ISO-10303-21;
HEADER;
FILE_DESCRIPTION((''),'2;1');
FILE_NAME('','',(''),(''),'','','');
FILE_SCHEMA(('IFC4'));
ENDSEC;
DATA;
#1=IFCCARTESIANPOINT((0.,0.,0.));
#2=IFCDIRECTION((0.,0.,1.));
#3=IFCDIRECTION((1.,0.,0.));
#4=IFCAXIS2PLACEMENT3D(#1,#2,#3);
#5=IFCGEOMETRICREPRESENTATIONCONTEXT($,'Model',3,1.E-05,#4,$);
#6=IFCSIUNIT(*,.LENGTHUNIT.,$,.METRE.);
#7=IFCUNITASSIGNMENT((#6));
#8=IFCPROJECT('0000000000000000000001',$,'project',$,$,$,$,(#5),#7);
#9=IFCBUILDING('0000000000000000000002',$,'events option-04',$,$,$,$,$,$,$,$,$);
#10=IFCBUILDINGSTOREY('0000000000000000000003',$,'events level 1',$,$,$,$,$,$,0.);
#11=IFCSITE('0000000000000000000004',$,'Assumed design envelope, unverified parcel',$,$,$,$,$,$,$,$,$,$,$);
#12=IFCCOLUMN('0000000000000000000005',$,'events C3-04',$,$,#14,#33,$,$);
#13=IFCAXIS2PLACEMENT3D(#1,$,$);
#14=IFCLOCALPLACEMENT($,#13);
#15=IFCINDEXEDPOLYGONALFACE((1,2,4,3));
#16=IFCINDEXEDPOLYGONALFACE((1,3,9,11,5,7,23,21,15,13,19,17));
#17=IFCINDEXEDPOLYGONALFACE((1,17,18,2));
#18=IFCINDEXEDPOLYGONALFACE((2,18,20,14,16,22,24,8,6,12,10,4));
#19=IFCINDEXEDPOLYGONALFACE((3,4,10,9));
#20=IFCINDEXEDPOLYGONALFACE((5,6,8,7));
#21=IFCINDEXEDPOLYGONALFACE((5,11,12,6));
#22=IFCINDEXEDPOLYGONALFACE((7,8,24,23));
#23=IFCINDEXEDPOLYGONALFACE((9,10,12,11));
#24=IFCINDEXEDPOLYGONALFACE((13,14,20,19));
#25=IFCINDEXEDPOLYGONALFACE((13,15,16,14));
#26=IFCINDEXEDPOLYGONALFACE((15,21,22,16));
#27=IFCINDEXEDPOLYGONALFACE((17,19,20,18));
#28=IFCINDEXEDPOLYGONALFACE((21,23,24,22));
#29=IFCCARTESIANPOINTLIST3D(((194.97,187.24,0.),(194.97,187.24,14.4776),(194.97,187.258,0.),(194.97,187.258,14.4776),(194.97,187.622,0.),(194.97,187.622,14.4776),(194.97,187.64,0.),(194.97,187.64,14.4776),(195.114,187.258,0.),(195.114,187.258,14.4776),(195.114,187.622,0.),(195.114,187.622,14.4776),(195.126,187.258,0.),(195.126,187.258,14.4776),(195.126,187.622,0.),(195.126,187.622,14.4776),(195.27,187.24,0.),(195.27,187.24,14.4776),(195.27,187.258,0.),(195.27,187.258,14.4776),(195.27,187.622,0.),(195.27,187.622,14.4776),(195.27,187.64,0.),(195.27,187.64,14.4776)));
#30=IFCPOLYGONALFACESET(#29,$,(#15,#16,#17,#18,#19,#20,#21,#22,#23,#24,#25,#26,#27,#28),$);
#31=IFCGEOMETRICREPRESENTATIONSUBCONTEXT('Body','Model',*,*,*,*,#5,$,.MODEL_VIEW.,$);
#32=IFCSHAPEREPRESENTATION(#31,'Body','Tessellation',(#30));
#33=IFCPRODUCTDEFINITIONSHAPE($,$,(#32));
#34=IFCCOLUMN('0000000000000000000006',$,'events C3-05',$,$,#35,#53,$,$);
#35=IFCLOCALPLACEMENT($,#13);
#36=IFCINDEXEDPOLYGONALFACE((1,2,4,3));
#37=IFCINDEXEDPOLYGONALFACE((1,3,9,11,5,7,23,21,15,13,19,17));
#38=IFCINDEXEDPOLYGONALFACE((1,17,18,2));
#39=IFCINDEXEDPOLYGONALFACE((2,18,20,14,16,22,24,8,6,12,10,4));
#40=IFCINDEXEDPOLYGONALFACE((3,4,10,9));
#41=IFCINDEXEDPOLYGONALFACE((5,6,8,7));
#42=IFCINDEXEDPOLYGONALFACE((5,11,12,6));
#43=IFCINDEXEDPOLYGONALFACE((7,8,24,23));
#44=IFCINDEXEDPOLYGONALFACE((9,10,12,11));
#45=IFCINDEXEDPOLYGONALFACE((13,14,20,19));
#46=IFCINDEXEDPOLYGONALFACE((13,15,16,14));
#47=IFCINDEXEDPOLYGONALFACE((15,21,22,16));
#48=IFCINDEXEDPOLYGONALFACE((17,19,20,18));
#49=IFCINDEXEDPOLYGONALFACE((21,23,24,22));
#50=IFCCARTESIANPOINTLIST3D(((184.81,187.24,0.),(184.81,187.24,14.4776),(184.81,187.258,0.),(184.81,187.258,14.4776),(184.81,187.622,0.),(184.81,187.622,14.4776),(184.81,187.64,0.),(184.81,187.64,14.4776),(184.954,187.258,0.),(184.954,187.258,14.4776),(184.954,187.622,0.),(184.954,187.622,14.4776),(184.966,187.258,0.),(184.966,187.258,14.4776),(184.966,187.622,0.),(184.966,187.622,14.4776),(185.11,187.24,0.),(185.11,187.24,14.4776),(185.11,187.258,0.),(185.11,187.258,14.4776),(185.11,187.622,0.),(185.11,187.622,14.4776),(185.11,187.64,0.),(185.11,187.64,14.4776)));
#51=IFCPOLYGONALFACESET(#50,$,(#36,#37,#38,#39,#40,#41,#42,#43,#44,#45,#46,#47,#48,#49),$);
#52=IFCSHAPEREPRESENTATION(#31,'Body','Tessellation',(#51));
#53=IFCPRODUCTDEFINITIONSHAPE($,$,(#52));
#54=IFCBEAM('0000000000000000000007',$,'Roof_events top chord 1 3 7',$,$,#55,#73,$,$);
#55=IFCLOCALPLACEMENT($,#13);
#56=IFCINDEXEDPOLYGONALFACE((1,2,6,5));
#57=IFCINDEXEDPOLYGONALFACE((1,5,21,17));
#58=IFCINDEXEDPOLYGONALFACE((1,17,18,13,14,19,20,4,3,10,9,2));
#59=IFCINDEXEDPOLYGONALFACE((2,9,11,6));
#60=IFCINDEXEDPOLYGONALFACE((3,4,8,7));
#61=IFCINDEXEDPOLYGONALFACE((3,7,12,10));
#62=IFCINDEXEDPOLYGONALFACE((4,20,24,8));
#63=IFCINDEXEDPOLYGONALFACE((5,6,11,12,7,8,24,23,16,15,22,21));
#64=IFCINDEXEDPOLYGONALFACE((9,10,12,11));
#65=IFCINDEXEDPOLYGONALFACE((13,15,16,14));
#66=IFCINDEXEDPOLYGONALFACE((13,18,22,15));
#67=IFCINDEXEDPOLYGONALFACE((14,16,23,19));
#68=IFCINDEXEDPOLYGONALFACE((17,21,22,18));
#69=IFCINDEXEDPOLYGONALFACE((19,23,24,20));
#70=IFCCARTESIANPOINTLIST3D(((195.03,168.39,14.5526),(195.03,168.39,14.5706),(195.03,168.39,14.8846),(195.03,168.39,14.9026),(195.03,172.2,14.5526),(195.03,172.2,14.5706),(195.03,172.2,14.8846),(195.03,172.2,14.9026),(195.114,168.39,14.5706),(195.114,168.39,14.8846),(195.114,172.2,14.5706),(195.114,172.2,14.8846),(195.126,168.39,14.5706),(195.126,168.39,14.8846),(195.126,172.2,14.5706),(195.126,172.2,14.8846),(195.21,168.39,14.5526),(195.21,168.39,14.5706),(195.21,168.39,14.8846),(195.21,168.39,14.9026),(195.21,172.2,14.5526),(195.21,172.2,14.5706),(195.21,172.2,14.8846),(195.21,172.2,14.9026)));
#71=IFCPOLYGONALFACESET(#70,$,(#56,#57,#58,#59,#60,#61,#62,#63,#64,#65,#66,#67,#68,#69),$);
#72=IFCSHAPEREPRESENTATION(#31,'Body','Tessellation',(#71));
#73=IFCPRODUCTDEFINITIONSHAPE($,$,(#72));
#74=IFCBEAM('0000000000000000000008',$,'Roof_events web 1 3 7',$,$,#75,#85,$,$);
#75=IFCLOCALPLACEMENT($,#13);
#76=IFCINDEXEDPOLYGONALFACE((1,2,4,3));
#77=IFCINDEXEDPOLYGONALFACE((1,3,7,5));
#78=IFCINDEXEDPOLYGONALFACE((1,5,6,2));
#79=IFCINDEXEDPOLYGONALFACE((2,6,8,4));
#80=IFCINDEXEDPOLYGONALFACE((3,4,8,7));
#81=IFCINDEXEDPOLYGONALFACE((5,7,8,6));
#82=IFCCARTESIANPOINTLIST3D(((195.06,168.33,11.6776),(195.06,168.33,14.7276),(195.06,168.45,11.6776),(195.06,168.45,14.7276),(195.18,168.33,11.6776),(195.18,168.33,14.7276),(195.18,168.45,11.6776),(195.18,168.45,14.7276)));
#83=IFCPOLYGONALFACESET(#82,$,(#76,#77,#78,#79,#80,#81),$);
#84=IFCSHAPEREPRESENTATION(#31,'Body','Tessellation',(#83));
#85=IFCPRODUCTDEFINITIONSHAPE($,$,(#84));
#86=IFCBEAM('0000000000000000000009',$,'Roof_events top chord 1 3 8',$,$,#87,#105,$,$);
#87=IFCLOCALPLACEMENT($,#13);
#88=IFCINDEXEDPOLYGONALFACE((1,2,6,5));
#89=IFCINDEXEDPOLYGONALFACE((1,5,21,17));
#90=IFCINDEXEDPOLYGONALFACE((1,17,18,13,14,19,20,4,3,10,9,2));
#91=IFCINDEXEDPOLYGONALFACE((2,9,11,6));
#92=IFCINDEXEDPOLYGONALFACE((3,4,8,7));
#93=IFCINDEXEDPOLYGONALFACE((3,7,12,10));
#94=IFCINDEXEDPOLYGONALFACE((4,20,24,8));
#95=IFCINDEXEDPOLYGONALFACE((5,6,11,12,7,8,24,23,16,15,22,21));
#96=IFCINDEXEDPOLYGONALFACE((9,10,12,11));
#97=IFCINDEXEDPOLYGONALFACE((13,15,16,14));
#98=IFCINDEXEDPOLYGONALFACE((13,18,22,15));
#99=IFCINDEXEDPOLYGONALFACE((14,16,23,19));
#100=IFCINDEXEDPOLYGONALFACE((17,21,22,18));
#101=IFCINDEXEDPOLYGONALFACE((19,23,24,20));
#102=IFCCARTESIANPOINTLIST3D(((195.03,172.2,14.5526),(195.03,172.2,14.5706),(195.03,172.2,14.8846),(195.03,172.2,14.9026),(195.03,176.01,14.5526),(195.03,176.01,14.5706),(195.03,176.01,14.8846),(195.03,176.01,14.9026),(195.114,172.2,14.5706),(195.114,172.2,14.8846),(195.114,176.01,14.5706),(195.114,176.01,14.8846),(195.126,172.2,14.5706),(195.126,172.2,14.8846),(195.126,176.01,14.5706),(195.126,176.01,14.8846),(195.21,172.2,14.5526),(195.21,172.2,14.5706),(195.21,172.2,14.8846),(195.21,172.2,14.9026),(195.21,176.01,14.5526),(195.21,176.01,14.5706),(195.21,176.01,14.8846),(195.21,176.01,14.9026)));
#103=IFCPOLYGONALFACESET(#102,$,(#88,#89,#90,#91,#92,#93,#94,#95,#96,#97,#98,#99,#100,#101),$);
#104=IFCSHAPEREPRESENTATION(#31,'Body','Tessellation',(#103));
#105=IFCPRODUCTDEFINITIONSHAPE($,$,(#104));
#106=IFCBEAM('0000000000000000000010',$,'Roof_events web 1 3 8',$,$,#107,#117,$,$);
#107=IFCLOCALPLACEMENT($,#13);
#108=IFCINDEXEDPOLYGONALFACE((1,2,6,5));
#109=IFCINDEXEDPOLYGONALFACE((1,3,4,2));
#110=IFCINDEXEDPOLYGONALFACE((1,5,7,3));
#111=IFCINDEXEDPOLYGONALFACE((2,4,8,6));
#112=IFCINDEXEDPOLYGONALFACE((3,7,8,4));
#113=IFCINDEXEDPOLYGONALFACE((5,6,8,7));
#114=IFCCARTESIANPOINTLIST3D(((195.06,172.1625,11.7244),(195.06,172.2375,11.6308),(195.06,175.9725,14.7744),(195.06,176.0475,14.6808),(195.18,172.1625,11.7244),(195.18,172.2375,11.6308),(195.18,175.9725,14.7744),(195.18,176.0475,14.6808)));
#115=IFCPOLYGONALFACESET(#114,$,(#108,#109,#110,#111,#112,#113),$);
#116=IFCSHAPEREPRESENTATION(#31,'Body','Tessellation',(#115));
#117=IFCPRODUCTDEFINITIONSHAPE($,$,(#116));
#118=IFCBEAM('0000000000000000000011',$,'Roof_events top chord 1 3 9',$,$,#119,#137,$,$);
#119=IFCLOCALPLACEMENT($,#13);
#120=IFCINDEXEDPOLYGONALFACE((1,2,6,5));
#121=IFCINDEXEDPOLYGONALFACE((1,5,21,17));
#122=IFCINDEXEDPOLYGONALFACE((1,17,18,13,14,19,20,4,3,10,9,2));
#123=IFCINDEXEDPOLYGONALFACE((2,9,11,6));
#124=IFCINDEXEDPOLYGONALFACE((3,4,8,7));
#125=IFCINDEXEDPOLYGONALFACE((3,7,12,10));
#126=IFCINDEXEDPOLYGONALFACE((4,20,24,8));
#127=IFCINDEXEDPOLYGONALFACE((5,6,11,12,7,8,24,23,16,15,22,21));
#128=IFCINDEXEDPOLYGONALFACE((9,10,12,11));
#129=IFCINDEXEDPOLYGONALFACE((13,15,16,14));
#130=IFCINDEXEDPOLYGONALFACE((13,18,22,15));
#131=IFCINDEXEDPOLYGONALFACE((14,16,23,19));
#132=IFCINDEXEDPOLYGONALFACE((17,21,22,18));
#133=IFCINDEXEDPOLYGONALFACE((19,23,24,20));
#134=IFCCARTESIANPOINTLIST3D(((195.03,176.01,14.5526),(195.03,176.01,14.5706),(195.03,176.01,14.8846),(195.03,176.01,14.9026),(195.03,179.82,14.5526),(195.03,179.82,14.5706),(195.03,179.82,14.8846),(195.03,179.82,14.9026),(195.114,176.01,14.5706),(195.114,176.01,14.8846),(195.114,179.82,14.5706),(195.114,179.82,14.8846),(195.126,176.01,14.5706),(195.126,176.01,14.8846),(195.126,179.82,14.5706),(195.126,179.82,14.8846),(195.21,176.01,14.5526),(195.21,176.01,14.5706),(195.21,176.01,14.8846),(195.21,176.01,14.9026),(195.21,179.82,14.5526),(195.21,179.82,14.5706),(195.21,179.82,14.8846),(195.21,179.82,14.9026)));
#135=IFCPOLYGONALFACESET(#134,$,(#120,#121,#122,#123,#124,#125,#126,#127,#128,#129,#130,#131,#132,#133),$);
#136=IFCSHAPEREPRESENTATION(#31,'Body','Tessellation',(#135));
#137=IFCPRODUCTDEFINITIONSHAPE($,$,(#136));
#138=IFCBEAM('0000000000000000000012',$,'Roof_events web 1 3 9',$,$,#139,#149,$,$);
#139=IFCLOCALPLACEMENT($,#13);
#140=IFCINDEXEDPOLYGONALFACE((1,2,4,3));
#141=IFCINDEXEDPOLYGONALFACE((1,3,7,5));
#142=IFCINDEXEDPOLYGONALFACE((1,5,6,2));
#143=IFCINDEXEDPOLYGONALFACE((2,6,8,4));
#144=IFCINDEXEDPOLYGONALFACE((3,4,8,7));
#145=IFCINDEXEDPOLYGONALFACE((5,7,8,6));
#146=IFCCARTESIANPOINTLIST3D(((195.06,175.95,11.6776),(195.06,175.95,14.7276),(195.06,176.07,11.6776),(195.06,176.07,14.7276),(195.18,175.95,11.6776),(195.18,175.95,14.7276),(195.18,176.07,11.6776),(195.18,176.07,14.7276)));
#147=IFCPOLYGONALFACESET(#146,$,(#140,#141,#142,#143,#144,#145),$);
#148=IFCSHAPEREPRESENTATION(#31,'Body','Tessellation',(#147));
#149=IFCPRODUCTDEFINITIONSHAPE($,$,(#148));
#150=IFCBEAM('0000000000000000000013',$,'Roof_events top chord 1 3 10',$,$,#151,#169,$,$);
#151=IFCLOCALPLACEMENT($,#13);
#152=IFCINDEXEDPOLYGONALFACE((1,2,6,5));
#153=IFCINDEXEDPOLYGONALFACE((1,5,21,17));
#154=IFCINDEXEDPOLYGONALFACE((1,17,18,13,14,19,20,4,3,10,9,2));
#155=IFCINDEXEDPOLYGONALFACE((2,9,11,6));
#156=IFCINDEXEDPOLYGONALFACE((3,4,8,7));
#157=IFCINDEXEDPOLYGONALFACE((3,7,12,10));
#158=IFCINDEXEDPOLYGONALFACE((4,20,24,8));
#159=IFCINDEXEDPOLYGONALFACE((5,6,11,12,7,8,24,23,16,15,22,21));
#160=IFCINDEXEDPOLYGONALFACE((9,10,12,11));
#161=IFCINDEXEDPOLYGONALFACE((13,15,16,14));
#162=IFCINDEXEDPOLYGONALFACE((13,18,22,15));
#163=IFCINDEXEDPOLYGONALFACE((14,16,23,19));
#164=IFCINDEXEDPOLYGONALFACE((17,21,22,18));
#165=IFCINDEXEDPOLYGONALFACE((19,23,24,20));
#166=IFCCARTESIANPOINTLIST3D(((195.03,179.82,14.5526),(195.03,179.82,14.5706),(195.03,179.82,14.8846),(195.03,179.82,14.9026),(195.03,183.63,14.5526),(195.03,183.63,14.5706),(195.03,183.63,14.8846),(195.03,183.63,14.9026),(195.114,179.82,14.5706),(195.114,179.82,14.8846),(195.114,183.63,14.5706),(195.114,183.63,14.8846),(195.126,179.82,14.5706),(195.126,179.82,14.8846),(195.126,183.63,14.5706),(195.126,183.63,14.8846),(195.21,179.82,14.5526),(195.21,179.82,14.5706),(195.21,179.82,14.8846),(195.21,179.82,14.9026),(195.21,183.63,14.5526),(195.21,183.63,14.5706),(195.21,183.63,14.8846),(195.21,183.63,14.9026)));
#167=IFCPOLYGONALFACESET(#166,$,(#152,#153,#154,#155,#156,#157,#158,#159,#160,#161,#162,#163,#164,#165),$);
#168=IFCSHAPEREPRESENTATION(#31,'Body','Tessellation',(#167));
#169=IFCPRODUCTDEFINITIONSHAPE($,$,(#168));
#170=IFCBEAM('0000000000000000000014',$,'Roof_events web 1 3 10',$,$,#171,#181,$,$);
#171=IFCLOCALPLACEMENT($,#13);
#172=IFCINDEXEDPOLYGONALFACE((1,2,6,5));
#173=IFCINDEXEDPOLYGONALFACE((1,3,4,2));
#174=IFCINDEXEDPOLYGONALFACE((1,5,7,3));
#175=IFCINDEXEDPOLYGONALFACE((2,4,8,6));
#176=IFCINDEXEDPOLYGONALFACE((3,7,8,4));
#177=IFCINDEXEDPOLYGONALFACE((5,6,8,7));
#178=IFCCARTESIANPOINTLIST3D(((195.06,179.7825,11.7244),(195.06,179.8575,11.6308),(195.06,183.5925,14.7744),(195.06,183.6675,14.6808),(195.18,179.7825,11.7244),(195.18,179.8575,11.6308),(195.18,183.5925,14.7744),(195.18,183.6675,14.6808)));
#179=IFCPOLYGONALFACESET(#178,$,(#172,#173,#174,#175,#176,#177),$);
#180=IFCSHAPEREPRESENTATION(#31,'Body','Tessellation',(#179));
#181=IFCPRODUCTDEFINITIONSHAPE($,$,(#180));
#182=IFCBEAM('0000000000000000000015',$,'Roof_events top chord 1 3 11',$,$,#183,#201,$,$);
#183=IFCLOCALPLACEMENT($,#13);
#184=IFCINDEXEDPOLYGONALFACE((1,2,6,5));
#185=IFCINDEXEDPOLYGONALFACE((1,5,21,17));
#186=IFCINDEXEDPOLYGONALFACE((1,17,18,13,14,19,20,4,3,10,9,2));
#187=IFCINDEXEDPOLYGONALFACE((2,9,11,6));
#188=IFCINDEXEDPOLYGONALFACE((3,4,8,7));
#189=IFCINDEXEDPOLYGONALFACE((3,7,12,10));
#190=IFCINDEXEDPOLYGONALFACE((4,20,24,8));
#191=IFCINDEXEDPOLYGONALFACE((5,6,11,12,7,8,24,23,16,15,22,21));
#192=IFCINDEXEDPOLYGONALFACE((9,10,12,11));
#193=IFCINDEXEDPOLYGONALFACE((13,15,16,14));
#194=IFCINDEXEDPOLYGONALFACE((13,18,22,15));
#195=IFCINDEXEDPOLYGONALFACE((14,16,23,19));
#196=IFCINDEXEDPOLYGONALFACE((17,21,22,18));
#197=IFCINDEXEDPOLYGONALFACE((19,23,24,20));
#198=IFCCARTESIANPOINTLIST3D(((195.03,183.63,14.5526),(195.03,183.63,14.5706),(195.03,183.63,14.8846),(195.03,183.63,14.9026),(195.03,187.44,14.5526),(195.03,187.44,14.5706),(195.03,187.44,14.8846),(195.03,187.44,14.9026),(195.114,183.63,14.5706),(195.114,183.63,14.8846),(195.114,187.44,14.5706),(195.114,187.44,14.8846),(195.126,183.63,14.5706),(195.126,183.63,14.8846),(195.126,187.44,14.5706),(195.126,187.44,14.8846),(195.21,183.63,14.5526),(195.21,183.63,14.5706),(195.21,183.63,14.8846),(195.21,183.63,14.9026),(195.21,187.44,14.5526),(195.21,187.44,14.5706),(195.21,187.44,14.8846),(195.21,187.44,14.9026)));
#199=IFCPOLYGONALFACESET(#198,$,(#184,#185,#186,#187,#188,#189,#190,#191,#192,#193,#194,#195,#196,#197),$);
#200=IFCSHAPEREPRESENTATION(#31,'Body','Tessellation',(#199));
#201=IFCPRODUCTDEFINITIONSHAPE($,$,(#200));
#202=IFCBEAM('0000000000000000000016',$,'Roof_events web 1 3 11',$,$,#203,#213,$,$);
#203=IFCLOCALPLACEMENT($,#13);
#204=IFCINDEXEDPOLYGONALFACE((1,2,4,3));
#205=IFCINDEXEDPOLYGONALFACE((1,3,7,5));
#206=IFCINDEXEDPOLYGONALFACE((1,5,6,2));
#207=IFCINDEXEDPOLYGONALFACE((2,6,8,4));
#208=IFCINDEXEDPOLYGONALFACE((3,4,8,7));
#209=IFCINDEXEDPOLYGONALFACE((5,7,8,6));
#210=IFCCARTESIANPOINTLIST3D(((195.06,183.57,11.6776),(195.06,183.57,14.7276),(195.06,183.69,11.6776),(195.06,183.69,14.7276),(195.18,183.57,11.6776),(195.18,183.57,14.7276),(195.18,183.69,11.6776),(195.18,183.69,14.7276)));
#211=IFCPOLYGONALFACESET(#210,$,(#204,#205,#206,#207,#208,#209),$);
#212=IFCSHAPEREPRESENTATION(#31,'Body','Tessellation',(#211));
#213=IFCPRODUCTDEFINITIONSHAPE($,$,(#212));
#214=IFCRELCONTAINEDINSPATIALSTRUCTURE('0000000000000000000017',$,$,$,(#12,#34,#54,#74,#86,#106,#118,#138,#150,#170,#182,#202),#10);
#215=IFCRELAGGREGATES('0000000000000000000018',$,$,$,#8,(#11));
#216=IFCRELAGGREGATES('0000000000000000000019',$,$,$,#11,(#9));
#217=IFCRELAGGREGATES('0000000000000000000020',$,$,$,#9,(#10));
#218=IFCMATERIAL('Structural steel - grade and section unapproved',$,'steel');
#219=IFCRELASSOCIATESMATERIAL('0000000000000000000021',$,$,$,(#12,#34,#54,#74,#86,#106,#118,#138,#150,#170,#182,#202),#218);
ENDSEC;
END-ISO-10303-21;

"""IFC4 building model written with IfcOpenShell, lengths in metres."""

from ifc_helpers import new_model, si_unit, frame, origin_with_axes, place, context, subcontext, project, spatial, rectangle, i_section, extrude, material, element, save


model = new_model("IFC4")

# Units and contexts
model_context = context("Model", 3, precision=1e-05, world=origin_with_axes())
body_context = subcontext(model_context, "Body", "Model", "MODEL_VIEW")
ifc_project = project(units=[si_unit("LENGTHUNIT", "METRE")], contexts=[model_context])

# Site, building, storey
site = spatial("IfcSite", under=ifc_project, Name="Assumed design envelope, unverified parcel")
building = spatial("IfcBuilding", under=site, Name="events option-04")
storey = spatial("IfcBuildingStorey", under=building, Name="events level 1", Elevation=0.0)

# Columns
ifc_material_1 = material(Name="Structural steel - grade and section unapproved", Category="steel")
for number, where, z_axis, x_axis, name in (
    (1, (195.12, 187.44, 0.0), (0.0, 0.0, 1.0), (-1.0, 0.0, 0.0), "events C3-04"),
    (2, (184.96, 187.44, 0.0), (0.0, 0.0, 1.0), (-1.0, 0.0, 0.0), "events C3-05"),
):
    element("IfcColumn", number, at=place(None, frame(where, z_axis=z_axis, x_axis=x_axis)), inside=storey, material=ifc_material_1, Name=name, context=body_context, shape_type="SweptSolid", body=[
        extrude(i_section(OverallWidth=0.3, OverallDepth=0.4, WebThickness=0.012, FlangeThickness=0.018, FilletRadius=0.0), origin_with_axes(), (0.0, 0.0, 1.0), 14.4776),
    ])

# Beams
beam_1_placement = place(None, frame((195.12, 168.39, 14.7276), z_axis=(0.0, 1.0, 0.0), x_axis=(-1.0, 0.0, 0.0)))
element("IfcBeam", 3, at=beam_1_placement, inside=storey, material=ifc_material_1, Name="Roof_events top chord 1 3 7", context=body_context, shape_type="SweptSolid", body=[
    extrude(i_section(OverallWidth=0.18, OverallDepth=0.35, WebThickness=0.012, FlangeThickness=0.018, FilletRadius=0.0), origin_with_axes(), (0.0, 0.0, 1.0), 3.81),
])
beam_2_placement = place(None, frame((195.12, 168.39, 11.6776), z_axis=(0.0, 0.0, 1.0), x_axis=(-1.0, 0.0, 0.0)))
element("IfcBeam", 4, at=beam_2_placement, inside=storey, material=ifc_material_1, Name="Roof_events web 1 3 7", context=body_context, shape_type="SweptSolid", body=[
    extrude(rectangle(XDim=0.12, YDim=0.12), origin_with_axes(), (0.0, 0.0, 1.0), 3.05),
])
beam_3_placement = place(None, frame((195.12, 172.2, 14.7276), z_axis=(0.0, 1.0, 0.0), x_axis=(-1.0, 0.0, 0.0)))
element("IfcBeam", 5, at=beam_3_placement, inside=storey, material=ifc_material_1, Name="Roof_events top chord 1 3 8", context=body_context, shape_type="SweptSolid", body=[
    extrude(i_section(OverallWidth=0.18, OverallDepth=0.35, WebThickness=0.012, FlangeThickness=0.018, FilletRadius=0.0), origin_with_axes(), (0.0, 0.0, 1.0), 3.81),
])
beam_4_placement = place(None, frame((195.12, 172.2, 11.6776), z_axis=(0.0, 0.780669, 0.624945), x_axis=(-1.0, 0.0, 0.0)))
element("IfcBeam", 6, at=beam_4_placement, inside=storey, material=ifc_material_1, Name="Roof_events web 1 3 8", context=body_context, shape_type="SweptSolid", body=[
    extrude(rectangle(XDim=0.12, YDim=0.12), origin_with_axes(), (0.0, 0.0, 1.0), 4.8804),
])
beam_5_placement = place(None, frame((195.12, 176.01, 14.7276), z_axis=(0.0, 1.0, 0.0), x_axis=(-1.0, 0.0, 0.0)))
element("IfcBeam", 7, at=beam_5_placement, inside=storey, material=ifc_material_1, Name="Roof_events top chord 1 3 9", context=body_context, shape_type="SweptSolid", body=[
    extrude(i_section(OverallWidth=0.18, OverallDepth=0.35, WebThickness=0.012, FlangeThickness=0.018, FilletRadius=0.0), origin_with_axes(), (0.0, 0.0, 1.0), 3.81),
])
beam_6_placement = place(None, frame((195.12, 176.01, 11.6776), z_axis=(0.0, 0.0, 1.0), x_axis=(-1.0, 0.0, 0.0)))
element("IfcBeam", 8, at=beam_6_placement, inside=storey, material=ifc_material_1, Name="Roof_events web 1 3 9", context=body_context, shape_type="SweptSolid", body=[
    extrude(rectangle(XDim=0.12, YDim=0.12), origin_with_axes(), (0.0, 0.0, 1.0), 3.05),
])
beam_7_placement = place(None, frame((195.12, 179.82, 14.7276), z_axis=(0.0, 1.0, 0.0), x_axis=(-1.0, 0.0, 0.0)))
element("IfcBeam", 9, at=beam_7_placement, inside=storey, material=ifc_material_1, Name="Roof_events top chord 1 3 10", context=body_context, shape_type="SweptSolid", body=[
    extrude(i_section(OverallWidth=0.18, OverallDepth=0.35, WebThickness=0.012, FlangeThickness=0.018, FilletRadius=0.0), origin_with_axes(), (0.0, 0.0, 1.0), 3.81),
])
beam_8_placement = place(None, frame((195.12, 179.82, 11.6776), z_axis=(0.0, 0.780669, 0.624945), x_axis=(-1.0, 0.0, 0.0)))
element("IfcBeam", 10, at=beam_8_placement, inside=storey, material=ifc_material_1, Name="Roof_events web 1 3 10", context=body_context, shape_type="SweptSolid", body=[
    extrude(rectangle(XDim=0.12, YDim=0.12), origin_with_axes(), (0.0, 0.0, 1.0), 4.8804),
])
beam_9_placement = place(None, frame((195.12, 183.63, 14.7276), z_axis=(0.0, 1.0, 0.0), x_axis=(-1.0, 0.0, 0.0)))
element("IfcBeam", 11, at=beam_9_placement, inside=storey, material=ifc_material_1, Name="Roof_events top chord 1 3 11", context=body_context, shape_type="SweptSolid", body=[
    extrude(i_section(OverallWidth=0.18, OverallDepth=0.35, WebThickness=0.012, FlangeThickness=0.018, FilletRadius=0.0), origin_with_axes(), (0.0, 0.0, 1.0), 3.81),
])
beam_10_placement = place(None, frame((195.12, 183.63, 11.6776), z_axis=(0.0, 0.0, 1.0), x_axis=(-1.0, 0.0, 0.0)))
element("IfcBeam", 12, at=beam_10_placement, inside=storey, material=ifc_material_1, Name="Roof_events web 1 3 11", context=body_context, shape_type="SweptSolid", body=[
    extrude(rectangle(XDim=0.12, YDim=0.12), origin_with_axes(), (0.0, 0.0, 1.0), 3.05),
])

save(model, "model.ifc")
